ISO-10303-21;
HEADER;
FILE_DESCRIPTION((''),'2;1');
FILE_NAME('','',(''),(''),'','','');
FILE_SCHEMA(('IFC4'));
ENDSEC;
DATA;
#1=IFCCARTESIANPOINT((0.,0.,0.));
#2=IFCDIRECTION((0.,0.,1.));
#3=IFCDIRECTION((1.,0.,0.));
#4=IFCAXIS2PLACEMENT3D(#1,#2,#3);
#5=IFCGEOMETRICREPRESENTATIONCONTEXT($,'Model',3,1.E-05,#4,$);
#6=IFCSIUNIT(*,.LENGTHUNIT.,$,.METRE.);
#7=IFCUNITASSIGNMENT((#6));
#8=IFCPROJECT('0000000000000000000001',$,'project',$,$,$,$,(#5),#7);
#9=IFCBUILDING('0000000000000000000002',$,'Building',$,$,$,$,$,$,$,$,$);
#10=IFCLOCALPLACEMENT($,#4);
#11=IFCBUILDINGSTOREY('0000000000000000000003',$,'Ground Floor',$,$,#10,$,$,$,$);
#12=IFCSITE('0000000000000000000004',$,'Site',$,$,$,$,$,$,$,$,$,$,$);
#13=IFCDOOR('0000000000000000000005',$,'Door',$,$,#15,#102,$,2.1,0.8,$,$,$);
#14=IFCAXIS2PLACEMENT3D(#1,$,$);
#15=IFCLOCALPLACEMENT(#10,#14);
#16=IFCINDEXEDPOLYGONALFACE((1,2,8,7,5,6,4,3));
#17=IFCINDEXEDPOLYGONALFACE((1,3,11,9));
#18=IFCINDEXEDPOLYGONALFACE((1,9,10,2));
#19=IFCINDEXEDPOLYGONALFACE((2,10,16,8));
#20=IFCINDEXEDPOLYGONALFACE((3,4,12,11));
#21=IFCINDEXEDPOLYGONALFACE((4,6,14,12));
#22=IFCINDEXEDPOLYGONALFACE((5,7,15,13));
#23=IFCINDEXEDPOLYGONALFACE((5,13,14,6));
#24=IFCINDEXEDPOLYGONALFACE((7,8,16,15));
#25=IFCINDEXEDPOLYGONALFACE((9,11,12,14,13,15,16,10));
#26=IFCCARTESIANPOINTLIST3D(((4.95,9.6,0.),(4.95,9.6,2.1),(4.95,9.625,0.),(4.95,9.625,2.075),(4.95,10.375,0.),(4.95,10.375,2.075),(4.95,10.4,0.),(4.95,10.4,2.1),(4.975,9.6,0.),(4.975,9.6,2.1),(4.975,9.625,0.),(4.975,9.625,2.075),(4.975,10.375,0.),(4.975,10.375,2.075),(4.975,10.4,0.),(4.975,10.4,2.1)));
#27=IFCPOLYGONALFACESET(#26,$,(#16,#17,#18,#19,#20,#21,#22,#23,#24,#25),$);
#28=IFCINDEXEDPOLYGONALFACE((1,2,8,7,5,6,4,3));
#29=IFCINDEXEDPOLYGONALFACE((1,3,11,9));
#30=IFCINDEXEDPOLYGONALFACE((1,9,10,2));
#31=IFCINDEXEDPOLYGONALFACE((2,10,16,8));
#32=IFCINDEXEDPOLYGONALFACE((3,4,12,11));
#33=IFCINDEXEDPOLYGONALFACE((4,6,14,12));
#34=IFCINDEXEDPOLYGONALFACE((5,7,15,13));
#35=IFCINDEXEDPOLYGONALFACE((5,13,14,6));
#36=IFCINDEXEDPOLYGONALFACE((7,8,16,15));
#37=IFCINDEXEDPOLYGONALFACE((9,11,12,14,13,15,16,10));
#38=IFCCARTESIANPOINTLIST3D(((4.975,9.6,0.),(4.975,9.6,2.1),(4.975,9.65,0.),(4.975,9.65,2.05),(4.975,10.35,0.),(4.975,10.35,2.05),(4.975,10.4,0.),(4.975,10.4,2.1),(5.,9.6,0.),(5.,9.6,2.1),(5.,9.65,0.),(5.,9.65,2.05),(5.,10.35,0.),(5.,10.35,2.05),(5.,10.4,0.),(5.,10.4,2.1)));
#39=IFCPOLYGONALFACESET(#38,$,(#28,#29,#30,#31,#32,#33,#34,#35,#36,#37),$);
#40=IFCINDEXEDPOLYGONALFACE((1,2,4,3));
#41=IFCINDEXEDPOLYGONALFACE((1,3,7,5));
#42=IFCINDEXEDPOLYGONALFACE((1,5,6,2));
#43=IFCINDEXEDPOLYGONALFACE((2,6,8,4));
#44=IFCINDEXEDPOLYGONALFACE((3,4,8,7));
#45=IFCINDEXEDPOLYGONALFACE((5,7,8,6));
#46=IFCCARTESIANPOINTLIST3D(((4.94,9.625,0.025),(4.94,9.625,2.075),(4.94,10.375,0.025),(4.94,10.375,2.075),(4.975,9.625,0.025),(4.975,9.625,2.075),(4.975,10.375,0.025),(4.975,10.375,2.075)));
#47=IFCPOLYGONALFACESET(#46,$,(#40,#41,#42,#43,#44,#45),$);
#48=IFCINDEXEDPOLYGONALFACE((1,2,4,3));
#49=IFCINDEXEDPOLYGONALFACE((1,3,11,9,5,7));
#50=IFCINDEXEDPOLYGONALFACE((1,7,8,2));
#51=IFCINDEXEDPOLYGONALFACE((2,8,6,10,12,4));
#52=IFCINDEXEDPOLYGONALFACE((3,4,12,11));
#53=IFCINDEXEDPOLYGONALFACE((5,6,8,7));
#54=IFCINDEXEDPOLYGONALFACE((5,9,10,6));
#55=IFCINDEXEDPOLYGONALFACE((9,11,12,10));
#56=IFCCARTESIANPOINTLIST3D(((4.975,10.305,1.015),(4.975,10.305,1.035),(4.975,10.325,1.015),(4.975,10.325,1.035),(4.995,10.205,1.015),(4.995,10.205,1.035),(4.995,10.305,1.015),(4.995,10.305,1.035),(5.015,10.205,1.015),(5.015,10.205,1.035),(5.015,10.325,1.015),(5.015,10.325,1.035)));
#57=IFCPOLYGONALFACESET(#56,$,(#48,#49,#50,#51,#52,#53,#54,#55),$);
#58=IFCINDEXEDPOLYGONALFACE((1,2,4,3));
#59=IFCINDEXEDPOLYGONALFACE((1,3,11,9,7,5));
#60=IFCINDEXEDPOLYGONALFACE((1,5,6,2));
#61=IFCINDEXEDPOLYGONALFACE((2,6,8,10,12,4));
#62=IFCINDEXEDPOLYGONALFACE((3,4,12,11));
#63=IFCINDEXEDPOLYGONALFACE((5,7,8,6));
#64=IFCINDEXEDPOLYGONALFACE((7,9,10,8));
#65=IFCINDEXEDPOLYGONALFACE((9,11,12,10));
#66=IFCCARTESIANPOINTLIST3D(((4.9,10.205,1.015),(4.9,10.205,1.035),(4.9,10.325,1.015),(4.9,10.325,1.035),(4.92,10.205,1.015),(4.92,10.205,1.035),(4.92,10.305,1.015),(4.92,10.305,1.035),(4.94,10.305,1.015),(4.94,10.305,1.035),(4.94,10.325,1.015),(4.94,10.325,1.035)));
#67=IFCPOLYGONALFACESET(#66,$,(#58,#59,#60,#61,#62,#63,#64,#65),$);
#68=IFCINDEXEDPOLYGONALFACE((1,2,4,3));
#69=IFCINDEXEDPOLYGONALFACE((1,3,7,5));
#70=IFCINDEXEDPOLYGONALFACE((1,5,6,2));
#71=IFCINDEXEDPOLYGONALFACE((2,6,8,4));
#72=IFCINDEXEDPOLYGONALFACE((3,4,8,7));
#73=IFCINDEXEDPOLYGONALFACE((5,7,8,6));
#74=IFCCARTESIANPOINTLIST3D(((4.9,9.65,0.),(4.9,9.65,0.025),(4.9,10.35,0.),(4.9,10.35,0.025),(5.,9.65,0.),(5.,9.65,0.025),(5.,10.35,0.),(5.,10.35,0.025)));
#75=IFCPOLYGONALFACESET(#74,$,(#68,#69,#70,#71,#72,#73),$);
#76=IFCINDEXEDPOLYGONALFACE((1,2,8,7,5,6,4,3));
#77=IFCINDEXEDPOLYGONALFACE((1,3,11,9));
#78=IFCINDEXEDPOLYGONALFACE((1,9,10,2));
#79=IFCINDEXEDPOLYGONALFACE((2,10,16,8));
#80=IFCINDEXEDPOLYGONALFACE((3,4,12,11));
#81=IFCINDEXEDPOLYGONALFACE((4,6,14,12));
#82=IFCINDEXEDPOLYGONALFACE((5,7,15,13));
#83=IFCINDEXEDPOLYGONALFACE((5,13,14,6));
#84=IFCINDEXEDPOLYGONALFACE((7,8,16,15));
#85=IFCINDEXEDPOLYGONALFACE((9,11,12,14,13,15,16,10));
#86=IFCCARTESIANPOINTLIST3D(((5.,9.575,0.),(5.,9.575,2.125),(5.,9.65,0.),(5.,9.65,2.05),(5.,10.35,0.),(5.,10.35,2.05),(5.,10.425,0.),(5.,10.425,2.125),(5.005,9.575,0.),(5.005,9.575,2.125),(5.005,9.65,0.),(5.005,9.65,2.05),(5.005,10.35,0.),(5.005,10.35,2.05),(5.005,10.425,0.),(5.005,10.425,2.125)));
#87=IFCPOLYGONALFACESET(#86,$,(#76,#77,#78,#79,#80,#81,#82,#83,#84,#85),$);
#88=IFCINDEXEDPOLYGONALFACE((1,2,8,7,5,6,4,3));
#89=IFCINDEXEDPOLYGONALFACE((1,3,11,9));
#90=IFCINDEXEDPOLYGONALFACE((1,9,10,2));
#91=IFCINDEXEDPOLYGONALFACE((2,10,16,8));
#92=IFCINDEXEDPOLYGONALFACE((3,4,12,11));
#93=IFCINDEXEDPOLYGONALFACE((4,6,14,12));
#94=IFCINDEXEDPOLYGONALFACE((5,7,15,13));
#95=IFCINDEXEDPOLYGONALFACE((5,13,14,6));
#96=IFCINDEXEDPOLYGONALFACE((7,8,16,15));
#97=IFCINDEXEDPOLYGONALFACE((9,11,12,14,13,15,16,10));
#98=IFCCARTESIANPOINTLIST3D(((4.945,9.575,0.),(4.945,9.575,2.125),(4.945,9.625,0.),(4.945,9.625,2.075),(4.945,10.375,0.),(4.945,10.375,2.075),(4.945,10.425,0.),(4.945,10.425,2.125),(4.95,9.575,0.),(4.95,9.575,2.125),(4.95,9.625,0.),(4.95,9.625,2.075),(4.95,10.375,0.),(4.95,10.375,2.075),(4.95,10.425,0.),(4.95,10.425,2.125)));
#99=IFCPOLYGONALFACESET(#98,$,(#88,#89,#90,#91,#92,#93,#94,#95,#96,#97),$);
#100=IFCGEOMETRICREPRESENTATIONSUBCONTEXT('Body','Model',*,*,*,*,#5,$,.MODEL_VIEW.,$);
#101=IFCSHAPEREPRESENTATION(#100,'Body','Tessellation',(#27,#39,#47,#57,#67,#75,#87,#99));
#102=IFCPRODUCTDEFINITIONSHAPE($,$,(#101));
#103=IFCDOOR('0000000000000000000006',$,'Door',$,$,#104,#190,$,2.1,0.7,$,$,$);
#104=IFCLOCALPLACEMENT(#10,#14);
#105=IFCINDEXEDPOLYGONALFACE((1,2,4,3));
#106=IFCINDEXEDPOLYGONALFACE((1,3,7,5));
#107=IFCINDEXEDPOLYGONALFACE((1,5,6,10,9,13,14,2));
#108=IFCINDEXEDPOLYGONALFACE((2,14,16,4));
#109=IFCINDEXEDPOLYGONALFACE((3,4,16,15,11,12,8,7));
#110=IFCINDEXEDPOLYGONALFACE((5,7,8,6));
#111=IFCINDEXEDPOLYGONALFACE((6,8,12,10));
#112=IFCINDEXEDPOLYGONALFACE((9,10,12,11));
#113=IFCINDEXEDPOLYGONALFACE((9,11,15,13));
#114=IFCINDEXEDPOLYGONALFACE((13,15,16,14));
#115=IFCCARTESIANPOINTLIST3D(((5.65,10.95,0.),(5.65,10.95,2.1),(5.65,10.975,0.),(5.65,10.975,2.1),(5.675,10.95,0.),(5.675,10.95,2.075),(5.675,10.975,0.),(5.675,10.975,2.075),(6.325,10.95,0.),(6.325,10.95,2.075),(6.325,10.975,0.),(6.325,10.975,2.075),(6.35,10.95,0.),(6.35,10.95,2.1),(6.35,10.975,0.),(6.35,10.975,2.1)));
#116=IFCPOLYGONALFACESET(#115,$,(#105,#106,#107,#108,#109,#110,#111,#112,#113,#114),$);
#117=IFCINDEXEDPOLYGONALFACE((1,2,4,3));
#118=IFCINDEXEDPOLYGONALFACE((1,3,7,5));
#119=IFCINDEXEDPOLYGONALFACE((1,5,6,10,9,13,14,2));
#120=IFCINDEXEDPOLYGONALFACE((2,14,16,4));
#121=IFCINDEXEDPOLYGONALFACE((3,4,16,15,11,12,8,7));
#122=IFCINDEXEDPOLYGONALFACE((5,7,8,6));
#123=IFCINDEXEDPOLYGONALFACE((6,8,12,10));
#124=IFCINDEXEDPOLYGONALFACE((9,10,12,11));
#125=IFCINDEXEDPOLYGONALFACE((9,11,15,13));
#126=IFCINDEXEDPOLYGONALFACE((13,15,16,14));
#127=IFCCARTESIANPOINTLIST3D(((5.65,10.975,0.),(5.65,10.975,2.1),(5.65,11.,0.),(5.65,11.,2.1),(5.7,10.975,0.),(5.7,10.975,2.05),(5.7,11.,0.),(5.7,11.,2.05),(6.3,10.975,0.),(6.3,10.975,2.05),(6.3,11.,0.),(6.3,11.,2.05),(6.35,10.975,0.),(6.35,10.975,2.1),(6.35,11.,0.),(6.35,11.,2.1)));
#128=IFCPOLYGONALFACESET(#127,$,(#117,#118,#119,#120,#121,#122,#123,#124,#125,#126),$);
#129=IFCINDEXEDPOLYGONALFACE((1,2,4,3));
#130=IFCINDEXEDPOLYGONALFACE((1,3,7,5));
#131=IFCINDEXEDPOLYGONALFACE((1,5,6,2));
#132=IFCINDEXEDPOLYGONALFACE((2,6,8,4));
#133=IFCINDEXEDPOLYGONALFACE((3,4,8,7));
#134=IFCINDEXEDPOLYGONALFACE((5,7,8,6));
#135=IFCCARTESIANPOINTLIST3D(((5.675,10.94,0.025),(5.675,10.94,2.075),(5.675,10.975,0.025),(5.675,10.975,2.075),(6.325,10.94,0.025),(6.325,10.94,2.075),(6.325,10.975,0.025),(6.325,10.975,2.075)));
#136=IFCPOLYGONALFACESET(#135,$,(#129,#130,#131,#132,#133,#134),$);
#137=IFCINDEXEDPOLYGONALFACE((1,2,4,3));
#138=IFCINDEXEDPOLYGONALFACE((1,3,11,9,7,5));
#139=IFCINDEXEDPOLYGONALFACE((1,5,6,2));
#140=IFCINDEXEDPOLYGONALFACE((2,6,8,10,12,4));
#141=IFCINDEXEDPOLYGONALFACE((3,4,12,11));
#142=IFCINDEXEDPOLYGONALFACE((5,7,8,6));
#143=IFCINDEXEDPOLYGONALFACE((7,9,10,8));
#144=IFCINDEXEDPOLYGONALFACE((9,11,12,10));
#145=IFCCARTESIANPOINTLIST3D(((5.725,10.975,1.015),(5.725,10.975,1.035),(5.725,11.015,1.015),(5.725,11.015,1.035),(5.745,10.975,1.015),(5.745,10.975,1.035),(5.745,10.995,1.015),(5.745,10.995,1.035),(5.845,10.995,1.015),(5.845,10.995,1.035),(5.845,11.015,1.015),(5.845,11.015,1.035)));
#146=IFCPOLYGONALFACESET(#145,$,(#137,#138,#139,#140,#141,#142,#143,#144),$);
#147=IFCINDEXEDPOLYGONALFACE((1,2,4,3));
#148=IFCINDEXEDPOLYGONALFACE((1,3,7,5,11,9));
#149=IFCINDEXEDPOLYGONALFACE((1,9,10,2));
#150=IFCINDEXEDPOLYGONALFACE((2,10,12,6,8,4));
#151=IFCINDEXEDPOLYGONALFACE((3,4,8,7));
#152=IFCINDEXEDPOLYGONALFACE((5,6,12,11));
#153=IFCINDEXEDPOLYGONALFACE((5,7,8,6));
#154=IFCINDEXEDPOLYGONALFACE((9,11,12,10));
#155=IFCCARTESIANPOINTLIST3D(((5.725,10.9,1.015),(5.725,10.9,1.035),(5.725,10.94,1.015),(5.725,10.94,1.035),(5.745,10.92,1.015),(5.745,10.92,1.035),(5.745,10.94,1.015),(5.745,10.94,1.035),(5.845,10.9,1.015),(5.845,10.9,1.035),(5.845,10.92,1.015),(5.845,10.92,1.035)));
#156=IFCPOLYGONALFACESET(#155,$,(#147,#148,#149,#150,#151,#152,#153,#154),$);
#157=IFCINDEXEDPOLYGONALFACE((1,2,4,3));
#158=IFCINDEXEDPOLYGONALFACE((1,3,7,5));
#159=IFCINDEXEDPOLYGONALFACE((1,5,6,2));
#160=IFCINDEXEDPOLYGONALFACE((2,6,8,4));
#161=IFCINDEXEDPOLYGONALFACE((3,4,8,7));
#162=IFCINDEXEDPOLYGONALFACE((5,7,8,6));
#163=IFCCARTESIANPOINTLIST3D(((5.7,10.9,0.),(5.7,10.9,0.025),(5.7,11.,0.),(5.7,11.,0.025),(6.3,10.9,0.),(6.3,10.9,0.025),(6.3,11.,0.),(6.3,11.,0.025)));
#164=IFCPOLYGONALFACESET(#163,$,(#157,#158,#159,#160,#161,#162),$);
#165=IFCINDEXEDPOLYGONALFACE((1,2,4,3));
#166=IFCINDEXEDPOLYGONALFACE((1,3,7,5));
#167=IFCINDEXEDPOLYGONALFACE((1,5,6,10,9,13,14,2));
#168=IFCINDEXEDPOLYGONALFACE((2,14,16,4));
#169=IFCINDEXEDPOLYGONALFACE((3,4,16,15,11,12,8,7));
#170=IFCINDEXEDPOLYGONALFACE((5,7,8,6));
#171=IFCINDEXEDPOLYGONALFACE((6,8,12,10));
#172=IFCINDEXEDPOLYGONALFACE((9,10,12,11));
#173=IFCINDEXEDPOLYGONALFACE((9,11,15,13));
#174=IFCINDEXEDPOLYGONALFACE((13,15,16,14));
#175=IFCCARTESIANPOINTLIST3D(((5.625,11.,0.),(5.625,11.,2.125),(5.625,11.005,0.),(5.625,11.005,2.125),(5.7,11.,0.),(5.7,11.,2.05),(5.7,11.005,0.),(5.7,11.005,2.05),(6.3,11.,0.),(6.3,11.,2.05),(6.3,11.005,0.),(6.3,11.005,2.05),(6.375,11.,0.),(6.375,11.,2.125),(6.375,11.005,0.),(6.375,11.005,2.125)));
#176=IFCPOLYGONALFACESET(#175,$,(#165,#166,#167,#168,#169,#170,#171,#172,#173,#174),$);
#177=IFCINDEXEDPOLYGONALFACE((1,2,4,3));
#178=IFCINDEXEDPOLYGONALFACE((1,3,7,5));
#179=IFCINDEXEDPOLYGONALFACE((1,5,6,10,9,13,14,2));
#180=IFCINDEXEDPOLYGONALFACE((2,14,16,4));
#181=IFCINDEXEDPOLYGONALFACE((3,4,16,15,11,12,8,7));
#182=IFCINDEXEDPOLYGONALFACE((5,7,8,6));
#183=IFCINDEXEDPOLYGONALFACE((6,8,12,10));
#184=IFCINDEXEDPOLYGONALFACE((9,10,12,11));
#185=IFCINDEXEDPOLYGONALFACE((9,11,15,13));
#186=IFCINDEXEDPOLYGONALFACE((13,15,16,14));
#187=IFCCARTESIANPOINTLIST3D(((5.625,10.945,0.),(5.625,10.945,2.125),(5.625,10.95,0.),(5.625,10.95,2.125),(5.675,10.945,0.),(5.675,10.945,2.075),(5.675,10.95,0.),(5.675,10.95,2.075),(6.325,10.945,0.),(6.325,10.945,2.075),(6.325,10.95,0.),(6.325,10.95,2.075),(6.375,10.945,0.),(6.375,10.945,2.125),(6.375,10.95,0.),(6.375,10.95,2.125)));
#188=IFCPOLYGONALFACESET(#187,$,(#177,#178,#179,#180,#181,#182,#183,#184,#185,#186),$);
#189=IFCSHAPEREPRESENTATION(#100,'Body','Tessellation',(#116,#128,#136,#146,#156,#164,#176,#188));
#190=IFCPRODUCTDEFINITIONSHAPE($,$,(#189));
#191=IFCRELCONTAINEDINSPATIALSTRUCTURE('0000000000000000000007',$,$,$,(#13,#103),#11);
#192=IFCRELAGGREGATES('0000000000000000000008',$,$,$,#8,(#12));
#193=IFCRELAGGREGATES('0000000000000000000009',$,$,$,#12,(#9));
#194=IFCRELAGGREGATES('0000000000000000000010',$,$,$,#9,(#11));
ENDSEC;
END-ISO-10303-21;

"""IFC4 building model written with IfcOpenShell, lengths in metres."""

from ifc_helpers import new_model, si_unit, frame, origin_with_axes, place, context, subcontext, project, spatial, line, indexed_curve, outline, extrude, element, save


model = new_model("IFC4")

# Units and contexts
model_context = context("Model", 3, precision=1e-05, world=origin_with_axes())
body_context = subcontext(model_context, "Body", "Model", "MODEL_VIEW")
ifc_project = project(units=[si_unit("LENGTHUNIT", "METRE")], contexts=[model_context])

# Site, building, storey
site = spatial("IfcSite", under=ifc_project, Name="Site")
building = spatial("IfcBuilding", under=site, Name="Building")
storey_placement = place(None, origin_with_axes())
storey = spatial("IfcBuildingStorey", under=building, at=storey_placement, Name="Ground Floor")

# Doors
door_1_placement = place(storey_placement, frame((5.0, 9.6, 0.0), z_axis=(0.0, 0.0, 1.0), x_axis=(0.0, 1.0, 0.0)))
element("IfcDoor", 1, at=door_1_placement, inside=storey, Name="Door", OverallHeight=2.1, OverallWidth=0.8, context=body_context, shape_type="SweptSolid", body=[
    extrude(outline(indexed_curve([(0.0, 0.0), (0.0, 2.1), (0.8, 2.1), (0.8, 0.0), (0.775, 0.0), (0.775, 2.075), (0.025, 2.075), (0.025, 0.0)], segments=[line(1, 2, 3, 4, 5, 6, 7, 8, 1)])), frame((0.0, 0.025, 0.0), z_axis=(0.0, -1.0, 0.0), x_axis=(1.0, 0.0, 0.0)), (0.0, 0.0, -1.0), 0.025),
    extrude(outline(indexed_curve([(0.0, 0.0), (0.0, 2.1), (0.8, 2.1), (0.8, 0.0), (0.75, 0.0), (0.75, 2.05), (0.05, 2.05), (0.05, 0.0)], segments=[line(1, 2, 3, 4, 5, 6, 7, 8, 1)])), frame((0.0, 0.0, 0.0), z_axis=(0.0, -1.0, 0.0), x_axis=(1.0, 0.0, 0.0)), (0.0, 0.0, -1.0), 0.025),
    extrude(outline(indexed_curve([(0.0, 0.0), (0.75, 0.0), (0.75, 0.035), (0.0, 0.035)], segments=[line(1, 2, 3, 4, 1)])), frame((0.025, 0.025, 0.025), z_axis=(0.0, 0.0, 1.0), x_axis=(1.0, 0.0, 0.0)), (0.0, 0.0, 1.0), 2.05),
    extrude(outline(indexed_curve([(0.0, 0.0), (0.0, -0.04), (-0.12, -0.04), (-0.12, -0.02), (-0.02, -0.02), (-0.02, 0.0)], segments=[line(1, 2, 3, 4, 5, 6, 1)])), frame((0.725, 0.025, 1.015), z_axis=(0.0, 0.0, 1.0), x_axis=(1.0, 0.0, 0.0)), (0.0, 0.0, 1.0), 0.02),
    extrude(outline(indexed_curve([(0.0, 0.0), (0.0, 0.04), (-0.12, 0.04), (-0.12, 0.02), (-0.02, 0.02), (-0.02, 0.0)], segments=[line(1, 2, 3, 4, 5, 6, 1)])), frame((0.725, 0.06, 1.015), z_axis=(0.0, 0.0, 1.0), x_axis=(1.0, 0.0, 0.0)), (0.0, 0.0, 1.0), 0.02),
    extrude(outline(indexed_curve([(0.0, 0.0), (0.7, 0.0), (0.7, 0.1), (0.0, 0.1)], segments=[line(1, 2, 3, 4, 1)])), frame((0.05, 0.0, 0.0), z_axis=(0.0, 0.0, 1.0), x_axis=(1.0, 0.0, 0.0)), (0.0, 0.0, 1.0), 0.025),
    extrude(outline(indexed_curve([(0.0, 0.0), (0.0, 2.125), (0.85, 2.125), (0.85, 0.0), (0.775, 0.0), (0.775, 2.05), (0.075, 2.05), (0.075, 0.0)], segments=[line(1, 2, 3, 4, 5, 6, 7, 8, 1)])), frame((-0.025, -0.005, 0.0), z_axis=(0.0, -1.0, 0.0), x_axis=(1.0, 0.0, 0.0)), (0.0, 0.0, -1.0), 0.005),
    extrude(outline(indexed_curve([(0.0, 0.0), (0.0, 2.125), (0.85, 2.125), (0.85, 0.0), (0.8, 0.0), (0.8, 2.075), (0.05, 2.075), (0.05, 0.0)], segments=[line(1, 2, 3, 4, 5, 6, 7, 8, 1)])), frame((-0.025, 0.05, 0.0), z_axis=(0.0, -1.0, 0.0), x_axis=(1.0, 0.0, 0.0)), (0.0, 0.0, -1.0), 0.005),
])
door_2_placement = place(storey_placement, frame((6.35, 11.0, 0.0), z_axis=(0.0, 0.0, 1.0), x_axis=(-1.0, 0.0, 0.0)))
element("IfcDoor", 2, at=door_2_placement, inside=storey, Name="Door", OverallHeight=2.1, OverallWidth=0.7, context=body_context, shape_type="SweptSolid", body=[
    extrude(outline(indexed_curve([(0.0, 0.0), (0.0, 2.1), (0.7, 2.1), (0.7, 0.0), (0.675, 0.0), (0.675, 2.075), (0.025, 2.075), (0.025, 0.0)], segments=[line(1, 2, 3, 4, 5, 6, 7, 8, 1)])), frame((0.0, 0.025, 0.0), z_axis=(0.0, -1.0, 0.0), x_axis=(1.0, 0.0, 0.0)), (0.0, 0.0, -1.0), 0.025),
    extrude(outline(indexed_curve([(0.0, 0.0), (0.0, 2.1), (0.7, 2.1), (0.7, 0.0), (0.65, 0.0), (0.65, 2.05), (0.05, 2.05), (0.05, 0.0)], segments=[line(1, 2, 3, 4, 5, 6, 7, 8, 1)])), frame((0.0, 0.0, 0.0), z_axis=(0.0, -1.0, 0.0), x_axis=(1.0, 0.0, 0.0)), (0.0, 0.0, -1.0), 0.025),
    extrude(outline(indexed_curve([(0.0, 0.0), (0.65, 0.0), (0.65, 0.035), (0.0, 0.035)], segments=[line(1, 2, 3, 4, 1)])), frame((0.025, 0.025, 0.025), z_axis=(0.0, 0.0, 1.0), x_axis=(1.0, 0.0, 0.0)), (0.0, 0.0, 1.0), 2.05),
    extrude(outline(indexed_curve([(0.0, 0.0), (0.0, -0.04), (-0.12, -0.04), (-0.12, -0.02), (-0.02, -0.02), (-0.02, 0.0)], segments=[line(1, 2, 3, 4, 5, 6, 1)])), frame((0.625, 0.025, 1.015), z_axis=(0.0, 0.0, 1.0), x_axis=(1.0, 0.0, 0.0)), (0.0, 0.0, 1.0), 0.02),
    extrude(outline(indexed_curve([(0.0, 0.0), (0.0, 0.04), (-0.12, 0.04), (-0.12, 0.02), (-0.02, 0.02), (-0.02, 0.0)], segments=[line(1, 2, 3, 4, 5, 6, 1)])), frame((0.625, 0.06, 1.015), z_axis=(0.0, 0.0, 1.0), x_axis=(1.0, 0.0, 0.0)), (0.0, 0.0, 1.0), 0.02),
    extrude(outline(indexed_curve([(0.0, 0.0), (0.6, 0.0), (0.6, 0.1), (0.0, 0.1)], segments=[line(1, 2, 3, 4, 1)])), frame((0.05, 0.0, 0.0), z_axis=(0.0, 0.0, 1.0), x_axis=(1.0, 0.0, 0.0)), (0.0, 0.0, 1.0), 0.025),
    extrude(outline(indexed_curve([(0.0, 0.0), (0.0, 2.125), (0.75, 2.125), (0.75, 0.0), (0.675, 0.0), (0.675, 2.05), (0.075, 2.05), (0.075, 0.0)], segments=[line(1, 2, 3, 4, 5, 6, 7, 8, 1)])), frame((-0.025, -0.005, 0.0), z_axis=(0.0, -1.0, 0.0), x_axis=(1.0, 0.0, 0.0)), (0.0, 0.0, -1.0), 0.005),
    extrude(outline(indexed_curve([(0.0, 0.0), (0.0, 2.125), (0.75, 2.125), (0.75, 0.0), (0.7, 0.0), (0.7, 2.075), (0.05, 2.075), (0.05, 0.0)], segments=[line(1, 2, 3, 4, 5, 6, 7, 8, 1)])), frame((-0.025, 0.05, 0.0), z_axis=(0.0, -1.0, 0.0), x_axis=(1.0, 0.0, 0.0)), (0.0, 0.0, -1.0), 0.005),
])

save(model, "model.ifc")
